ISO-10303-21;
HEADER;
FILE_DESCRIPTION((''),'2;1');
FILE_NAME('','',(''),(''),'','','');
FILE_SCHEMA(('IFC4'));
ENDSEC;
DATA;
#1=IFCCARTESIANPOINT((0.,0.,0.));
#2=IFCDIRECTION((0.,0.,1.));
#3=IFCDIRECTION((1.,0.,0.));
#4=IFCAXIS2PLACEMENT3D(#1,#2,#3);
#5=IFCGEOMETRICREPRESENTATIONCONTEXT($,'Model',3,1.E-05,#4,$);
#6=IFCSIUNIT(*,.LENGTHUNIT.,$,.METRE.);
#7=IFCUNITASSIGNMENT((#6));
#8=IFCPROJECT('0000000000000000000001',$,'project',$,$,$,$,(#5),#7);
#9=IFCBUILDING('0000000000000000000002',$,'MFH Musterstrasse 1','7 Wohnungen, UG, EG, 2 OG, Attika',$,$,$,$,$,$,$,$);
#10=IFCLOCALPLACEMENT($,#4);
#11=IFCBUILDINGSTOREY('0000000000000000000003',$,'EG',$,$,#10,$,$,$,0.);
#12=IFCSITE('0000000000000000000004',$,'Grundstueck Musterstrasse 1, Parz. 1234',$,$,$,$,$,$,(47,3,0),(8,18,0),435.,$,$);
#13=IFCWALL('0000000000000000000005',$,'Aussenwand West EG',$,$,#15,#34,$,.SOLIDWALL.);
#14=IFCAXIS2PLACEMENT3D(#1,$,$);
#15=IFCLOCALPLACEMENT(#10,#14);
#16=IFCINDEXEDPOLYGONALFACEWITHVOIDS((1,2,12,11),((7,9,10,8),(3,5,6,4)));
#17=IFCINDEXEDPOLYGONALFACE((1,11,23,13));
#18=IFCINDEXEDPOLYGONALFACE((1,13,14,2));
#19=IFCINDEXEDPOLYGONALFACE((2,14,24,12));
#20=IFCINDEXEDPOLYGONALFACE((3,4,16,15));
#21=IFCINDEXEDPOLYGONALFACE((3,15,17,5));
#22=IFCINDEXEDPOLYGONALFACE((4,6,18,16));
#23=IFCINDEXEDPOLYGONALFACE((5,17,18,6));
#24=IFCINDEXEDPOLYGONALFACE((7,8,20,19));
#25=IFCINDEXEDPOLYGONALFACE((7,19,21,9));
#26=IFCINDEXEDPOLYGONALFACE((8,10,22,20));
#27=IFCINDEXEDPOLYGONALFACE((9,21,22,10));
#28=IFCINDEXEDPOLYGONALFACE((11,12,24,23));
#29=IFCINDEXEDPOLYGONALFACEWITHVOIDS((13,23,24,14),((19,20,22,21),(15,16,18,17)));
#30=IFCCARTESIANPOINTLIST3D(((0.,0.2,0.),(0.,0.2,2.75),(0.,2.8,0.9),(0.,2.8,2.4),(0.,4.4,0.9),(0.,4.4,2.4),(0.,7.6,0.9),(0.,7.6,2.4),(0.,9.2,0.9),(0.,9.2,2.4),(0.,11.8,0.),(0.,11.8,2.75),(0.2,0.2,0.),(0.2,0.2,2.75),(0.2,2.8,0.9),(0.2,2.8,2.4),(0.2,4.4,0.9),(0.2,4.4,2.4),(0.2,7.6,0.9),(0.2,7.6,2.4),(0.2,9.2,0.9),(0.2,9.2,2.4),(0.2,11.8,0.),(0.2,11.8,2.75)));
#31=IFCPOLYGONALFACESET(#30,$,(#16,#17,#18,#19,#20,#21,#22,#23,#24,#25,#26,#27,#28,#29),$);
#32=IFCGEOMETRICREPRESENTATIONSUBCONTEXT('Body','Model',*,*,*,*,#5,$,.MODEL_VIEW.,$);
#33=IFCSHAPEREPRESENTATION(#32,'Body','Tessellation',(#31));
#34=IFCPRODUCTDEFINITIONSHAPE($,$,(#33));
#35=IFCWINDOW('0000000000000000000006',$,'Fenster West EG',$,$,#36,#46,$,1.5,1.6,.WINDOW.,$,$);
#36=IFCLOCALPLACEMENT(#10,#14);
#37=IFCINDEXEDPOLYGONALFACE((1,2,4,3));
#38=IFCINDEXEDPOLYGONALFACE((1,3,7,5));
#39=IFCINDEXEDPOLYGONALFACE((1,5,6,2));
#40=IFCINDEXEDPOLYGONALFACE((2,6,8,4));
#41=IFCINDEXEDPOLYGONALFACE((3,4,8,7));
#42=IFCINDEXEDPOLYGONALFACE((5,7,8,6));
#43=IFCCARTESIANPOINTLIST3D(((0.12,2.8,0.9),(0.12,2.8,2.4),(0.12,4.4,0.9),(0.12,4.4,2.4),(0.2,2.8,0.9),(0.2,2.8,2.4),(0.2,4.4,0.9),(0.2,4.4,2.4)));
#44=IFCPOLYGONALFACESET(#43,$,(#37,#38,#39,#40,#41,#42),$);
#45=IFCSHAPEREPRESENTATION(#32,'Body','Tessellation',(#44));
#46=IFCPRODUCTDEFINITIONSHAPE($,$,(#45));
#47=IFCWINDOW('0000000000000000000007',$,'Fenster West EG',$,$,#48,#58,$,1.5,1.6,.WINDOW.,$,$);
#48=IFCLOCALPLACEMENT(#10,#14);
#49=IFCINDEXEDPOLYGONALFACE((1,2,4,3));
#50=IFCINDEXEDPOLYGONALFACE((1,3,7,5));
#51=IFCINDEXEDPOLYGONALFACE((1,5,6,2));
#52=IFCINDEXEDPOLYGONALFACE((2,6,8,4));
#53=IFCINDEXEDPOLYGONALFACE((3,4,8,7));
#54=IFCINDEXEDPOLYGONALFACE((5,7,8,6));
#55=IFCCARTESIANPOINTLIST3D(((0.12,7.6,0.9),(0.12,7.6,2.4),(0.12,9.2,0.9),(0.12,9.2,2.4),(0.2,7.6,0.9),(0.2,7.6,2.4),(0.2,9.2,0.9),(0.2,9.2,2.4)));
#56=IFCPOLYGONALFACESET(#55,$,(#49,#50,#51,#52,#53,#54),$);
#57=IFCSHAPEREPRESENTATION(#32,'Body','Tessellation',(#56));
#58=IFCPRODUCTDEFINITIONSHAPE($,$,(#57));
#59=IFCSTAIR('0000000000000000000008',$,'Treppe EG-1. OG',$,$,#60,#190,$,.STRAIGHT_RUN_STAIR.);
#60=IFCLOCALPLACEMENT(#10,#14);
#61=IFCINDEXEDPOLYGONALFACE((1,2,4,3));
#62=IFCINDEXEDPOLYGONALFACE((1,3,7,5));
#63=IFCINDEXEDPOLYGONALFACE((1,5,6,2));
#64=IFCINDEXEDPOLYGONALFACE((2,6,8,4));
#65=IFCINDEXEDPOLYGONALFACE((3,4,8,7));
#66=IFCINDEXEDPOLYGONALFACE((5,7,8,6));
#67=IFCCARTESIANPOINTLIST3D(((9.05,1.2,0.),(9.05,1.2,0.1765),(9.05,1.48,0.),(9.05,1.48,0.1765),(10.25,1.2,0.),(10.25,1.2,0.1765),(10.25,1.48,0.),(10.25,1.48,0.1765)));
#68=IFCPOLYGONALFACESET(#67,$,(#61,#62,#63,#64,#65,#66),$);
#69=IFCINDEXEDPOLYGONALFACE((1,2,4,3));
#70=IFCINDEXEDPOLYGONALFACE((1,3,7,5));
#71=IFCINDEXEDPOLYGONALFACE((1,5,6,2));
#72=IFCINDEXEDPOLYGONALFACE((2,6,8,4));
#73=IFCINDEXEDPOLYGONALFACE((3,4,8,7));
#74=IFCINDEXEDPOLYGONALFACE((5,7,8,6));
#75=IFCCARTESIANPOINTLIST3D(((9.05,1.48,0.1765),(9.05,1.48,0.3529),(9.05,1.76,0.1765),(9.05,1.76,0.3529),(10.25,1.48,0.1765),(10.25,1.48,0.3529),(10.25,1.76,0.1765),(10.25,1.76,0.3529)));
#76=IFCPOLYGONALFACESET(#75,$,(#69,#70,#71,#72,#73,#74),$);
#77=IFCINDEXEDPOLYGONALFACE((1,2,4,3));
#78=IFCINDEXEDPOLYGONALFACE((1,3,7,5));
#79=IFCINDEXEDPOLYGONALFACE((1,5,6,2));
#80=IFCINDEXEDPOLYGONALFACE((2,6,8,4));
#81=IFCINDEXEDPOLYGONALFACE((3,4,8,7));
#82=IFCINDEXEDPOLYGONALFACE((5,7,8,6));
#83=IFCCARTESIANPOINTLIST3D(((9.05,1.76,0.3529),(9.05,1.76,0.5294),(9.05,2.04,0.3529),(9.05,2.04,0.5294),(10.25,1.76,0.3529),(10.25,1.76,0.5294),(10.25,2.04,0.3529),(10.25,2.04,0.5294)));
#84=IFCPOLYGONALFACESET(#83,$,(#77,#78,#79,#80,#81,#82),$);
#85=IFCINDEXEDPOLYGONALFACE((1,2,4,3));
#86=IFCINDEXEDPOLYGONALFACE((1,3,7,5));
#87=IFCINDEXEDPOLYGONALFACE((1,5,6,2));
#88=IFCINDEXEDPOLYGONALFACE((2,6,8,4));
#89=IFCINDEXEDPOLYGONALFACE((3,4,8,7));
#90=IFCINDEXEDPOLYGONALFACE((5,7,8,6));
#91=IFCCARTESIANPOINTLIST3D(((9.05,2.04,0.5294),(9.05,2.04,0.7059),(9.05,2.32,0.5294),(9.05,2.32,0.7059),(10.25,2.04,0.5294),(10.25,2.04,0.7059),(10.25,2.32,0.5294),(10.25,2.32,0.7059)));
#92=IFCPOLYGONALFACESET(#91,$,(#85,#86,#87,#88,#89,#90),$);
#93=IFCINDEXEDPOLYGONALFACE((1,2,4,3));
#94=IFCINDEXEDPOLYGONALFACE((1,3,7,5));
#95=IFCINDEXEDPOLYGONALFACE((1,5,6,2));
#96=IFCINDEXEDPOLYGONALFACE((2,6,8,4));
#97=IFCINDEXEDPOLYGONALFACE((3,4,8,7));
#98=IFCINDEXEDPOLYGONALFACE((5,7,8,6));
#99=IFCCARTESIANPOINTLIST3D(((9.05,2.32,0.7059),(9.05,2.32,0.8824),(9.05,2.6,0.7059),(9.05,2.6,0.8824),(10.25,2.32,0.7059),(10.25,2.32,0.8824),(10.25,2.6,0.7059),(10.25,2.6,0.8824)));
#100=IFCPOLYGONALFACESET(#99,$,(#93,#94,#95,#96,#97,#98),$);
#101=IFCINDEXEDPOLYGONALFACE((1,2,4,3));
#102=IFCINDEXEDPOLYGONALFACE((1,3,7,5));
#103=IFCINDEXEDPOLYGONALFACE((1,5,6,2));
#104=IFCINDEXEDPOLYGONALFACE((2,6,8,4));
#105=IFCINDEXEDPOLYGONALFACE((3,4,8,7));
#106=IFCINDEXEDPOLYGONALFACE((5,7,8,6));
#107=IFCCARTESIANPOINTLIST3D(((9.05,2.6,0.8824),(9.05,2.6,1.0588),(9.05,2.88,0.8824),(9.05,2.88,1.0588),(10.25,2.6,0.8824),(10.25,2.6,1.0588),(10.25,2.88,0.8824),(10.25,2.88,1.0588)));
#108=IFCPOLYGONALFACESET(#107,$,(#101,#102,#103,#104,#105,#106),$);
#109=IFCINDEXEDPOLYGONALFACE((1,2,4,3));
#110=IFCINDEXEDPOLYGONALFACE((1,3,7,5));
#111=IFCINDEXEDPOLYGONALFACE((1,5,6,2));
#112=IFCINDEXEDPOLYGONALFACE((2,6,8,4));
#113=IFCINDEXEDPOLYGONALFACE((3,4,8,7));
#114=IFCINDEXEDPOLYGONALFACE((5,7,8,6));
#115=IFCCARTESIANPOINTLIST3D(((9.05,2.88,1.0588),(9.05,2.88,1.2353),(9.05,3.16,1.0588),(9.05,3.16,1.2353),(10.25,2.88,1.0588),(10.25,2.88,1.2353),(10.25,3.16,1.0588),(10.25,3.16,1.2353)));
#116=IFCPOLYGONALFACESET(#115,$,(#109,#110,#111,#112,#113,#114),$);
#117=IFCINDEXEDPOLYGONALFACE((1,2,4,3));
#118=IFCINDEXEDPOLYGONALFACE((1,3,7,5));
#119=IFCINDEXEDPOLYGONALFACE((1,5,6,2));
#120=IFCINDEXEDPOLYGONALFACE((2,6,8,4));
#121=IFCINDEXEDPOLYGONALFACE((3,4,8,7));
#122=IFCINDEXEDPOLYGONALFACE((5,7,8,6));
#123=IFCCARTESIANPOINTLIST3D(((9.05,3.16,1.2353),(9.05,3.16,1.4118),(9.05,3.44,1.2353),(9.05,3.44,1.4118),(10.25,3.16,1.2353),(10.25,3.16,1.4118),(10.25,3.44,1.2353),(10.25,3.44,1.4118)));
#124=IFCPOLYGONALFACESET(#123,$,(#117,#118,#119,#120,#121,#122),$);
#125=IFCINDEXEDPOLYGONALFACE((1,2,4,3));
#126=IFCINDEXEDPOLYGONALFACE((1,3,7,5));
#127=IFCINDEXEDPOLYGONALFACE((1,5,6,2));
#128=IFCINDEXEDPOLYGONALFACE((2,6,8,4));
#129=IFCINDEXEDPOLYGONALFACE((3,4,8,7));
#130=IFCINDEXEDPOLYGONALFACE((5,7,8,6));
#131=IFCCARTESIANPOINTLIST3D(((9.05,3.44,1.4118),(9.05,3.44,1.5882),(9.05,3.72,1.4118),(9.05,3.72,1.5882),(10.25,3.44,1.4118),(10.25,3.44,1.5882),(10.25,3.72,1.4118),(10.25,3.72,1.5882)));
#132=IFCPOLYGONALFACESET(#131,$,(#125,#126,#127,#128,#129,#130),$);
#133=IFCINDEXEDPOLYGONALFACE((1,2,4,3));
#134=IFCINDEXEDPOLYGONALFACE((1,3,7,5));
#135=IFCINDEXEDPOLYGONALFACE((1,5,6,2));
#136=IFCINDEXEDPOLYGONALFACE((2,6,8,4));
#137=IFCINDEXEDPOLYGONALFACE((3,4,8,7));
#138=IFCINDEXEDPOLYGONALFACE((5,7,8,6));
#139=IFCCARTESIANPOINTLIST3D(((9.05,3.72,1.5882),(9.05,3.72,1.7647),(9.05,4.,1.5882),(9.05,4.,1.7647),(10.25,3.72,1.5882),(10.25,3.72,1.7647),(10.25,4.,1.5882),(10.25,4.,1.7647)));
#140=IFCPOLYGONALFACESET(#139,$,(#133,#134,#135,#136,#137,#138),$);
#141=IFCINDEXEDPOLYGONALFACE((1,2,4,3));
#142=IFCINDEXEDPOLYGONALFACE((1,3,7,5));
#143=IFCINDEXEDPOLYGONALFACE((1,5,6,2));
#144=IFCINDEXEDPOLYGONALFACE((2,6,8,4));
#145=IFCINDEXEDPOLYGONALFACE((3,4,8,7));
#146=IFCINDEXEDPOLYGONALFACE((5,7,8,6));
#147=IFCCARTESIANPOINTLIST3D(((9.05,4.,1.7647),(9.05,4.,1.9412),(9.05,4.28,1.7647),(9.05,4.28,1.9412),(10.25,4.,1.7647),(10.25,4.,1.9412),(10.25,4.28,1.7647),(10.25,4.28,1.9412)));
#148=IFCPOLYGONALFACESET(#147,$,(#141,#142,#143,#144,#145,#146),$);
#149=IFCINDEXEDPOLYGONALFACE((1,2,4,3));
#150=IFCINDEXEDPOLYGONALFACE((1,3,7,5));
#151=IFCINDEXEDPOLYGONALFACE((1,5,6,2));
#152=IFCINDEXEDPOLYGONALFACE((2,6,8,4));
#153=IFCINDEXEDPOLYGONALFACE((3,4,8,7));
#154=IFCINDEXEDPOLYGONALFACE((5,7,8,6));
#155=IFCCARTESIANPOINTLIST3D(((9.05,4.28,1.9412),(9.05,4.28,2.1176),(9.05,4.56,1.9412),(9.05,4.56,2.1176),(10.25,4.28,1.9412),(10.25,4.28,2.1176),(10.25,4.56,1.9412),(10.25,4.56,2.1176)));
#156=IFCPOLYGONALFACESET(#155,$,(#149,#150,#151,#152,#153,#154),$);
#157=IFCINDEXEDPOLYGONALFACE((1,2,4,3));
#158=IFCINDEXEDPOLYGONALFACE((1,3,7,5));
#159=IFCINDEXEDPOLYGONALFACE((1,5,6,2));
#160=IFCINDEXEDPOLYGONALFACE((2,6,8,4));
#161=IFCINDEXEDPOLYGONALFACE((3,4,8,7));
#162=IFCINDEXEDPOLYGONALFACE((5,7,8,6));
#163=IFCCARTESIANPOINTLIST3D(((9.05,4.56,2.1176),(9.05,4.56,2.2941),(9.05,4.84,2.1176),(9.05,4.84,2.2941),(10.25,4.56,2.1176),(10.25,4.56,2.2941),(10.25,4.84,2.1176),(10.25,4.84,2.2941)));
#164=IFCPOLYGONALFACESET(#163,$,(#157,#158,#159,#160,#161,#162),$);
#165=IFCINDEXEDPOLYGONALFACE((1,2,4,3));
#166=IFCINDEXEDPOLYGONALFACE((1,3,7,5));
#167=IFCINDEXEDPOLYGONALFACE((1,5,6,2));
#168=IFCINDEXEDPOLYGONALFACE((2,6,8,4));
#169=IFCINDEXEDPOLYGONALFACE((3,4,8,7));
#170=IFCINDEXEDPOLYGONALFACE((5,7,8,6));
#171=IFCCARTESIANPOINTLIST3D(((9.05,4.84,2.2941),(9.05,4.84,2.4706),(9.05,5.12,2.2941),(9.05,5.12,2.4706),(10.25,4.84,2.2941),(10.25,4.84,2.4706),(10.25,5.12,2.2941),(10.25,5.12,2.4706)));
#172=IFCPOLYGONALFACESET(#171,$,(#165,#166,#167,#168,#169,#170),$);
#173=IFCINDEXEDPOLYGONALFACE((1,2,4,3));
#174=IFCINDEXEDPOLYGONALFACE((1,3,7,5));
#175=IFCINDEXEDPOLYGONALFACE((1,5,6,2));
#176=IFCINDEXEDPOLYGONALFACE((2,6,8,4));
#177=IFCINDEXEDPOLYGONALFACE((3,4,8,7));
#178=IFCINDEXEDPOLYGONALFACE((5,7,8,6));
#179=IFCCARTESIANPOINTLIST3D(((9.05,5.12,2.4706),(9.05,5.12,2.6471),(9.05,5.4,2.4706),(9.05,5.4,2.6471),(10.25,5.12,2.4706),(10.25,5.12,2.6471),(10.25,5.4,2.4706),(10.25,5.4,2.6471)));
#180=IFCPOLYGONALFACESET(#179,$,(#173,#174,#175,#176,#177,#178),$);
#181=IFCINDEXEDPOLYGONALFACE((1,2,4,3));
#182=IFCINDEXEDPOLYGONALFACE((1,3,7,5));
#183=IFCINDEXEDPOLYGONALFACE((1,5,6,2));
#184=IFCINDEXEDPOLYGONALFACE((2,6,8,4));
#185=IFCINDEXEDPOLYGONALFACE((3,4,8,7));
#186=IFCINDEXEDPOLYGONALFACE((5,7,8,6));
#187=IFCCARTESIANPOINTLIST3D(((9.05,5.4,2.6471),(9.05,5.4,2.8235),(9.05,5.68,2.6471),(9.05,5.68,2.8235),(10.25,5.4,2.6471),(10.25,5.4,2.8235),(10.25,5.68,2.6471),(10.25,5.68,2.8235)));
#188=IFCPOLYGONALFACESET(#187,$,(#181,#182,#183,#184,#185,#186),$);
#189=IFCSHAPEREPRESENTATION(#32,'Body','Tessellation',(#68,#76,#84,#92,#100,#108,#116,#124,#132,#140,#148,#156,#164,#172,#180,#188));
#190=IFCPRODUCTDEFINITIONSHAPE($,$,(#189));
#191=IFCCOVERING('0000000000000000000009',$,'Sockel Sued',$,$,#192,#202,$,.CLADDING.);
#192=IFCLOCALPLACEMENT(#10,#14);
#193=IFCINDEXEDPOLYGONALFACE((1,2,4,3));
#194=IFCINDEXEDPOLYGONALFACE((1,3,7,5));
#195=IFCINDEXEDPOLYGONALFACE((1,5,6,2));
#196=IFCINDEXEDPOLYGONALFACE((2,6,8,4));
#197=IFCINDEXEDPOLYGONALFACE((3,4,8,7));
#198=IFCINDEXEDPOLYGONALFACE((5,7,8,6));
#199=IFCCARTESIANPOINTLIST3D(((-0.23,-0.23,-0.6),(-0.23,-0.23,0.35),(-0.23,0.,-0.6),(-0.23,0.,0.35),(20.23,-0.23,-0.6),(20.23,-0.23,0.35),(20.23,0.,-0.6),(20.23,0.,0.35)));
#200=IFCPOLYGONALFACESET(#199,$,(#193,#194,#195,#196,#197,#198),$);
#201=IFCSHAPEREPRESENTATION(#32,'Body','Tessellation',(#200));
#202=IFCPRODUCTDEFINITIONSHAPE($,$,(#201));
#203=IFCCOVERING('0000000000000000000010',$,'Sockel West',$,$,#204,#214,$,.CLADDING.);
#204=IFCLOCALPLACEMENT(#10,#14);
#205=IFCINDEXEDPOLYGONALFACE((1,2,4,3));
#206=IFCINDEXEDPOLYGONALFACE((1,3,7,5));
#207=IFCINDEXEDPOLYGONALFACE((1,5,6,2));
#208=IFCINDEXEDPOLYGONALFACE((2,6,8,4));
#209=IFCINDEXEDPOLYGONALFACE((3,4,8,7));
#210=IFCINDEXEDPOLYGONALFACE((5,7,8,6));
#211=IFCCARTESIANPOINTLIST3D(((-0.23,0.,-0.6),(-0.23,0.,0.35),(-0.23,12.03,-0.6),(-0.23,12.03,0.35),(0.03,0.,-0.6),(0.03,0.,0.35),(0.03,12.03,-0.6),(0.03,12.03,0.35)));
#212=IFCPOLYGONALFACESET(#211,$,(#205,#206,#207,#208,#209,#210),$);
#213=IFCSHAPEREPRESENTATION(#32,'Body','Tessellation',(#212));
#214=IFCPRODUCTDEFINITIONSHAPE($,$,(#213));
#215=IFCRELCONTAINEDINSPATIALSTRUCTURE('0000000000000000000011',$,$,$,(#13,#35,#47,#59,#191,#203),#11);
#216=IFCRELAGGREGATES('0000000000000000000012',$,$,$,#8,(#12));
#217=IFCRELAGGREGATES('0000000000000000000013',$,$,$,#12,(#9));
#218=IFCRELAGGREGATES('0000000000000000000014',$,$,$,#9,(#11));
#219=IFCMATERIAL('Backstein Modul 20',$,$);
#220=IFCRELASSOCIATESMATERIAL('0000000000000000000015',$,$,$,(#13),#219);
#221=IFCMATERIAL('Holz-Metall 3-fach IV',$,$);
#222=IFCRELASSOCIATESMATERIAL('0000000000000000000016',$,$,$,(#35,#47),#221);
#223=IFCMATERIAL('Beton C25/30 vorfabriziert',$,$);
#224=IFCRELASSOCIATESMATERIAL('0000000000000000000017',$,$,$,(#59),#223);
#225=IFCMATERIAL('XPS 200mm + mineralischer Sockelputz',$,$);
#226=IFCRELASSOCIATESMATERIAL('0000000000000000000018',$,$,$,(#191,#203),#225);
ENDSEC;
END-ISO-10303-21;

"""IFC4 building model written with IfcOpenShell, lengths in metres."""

from ifc_helpers import new_model, si_unit, frame, frame_2d, origin_with_axes, place, context, subcontext, project, spatial, rectangle, extrude, material, element, fill, save


model = new_model("IFC4")

# Units and contexts
model_context = context("Model", 3, precision=1e-05, world=origin_with_axes())
body_context = subcontext(model_context, "Body", "Model", "MODEL_VIEW")
ifc_project = project(units=[si_unit("LENGTHUNIT", "METRE")], contexts=[model_context])

# Site, building, storey
site = spatial("IfcSite", under=ifc_project, Name="Grundstueck Musterstrasse 1, Parz. 1234", RefLatitude=(47, 3, 0), RefLongitude=(8, 18, 0), RefElevation=435.0)
building = spatial("IfcBuilding", under=site, Name="MFH Musterstrasse 1", Description="7 Wohnungen, UG, EG, 2 OG, Attika")
storey_placement = place(None, origin_with_axes())
storey = spatial("IfcBuildingStorey", under=building, at=storey_placement, Name="EG", Elevation=0.0)

# Shared definitions
ifc_material_1 = material(Name="Backstein Modul 20")
ifc_material_2 = material(Name="Holz-Metall 3-fach IV")

# Wall, openings, windows
wall_1_placement = place(storey_placement, frame((0.0, 0.2, 0.0), z_axis=(0.0, 0.0, 1.0), x_axis=(1.0, 0.0, 0.0)))
wall_1 = element("IfcWall", 1, at=wall_1_placement, inside=storey, material=ifc_material_1, Name="Aussenwand West EG", PredefinedType="SOLIDWALL", context=body_context, shape_type="SweptSolid", body=[
    extrude(rectangle(XDim=0.2, YDim=11.6, at=frame_2d((0.1, 5.8))), origin_with_axes(), (0.0, 0.0, 1.0), 2.75),
])
opening_1_placement = place(wall_1_placement, frame((-0.21, 2.6, 0.9), z_axis=(0.0, 0.0, 1.0), x_axis=(1.0, 0.0, 0.0)))
opening_1 = element("IfcOpeningElement", 2, at=opening_1_placement, cuts=wall_1, context=body_context, shape_type="SweptSolid", body=[
    extrude(rectangle(XDim=0.42, YDim=1.6, at=frame_2d((0.21, 0.8))), origin_with_axes(), (0.0, 0.0, 1.0), 1.5),
])
opening_2_placement = place(wall_1_placement, frame((-0.21, 7.4, 0.9), z_axis=(0.0, 0.0, 1.0), x_axis=(1.0, 0.0, 0.0)))
opening_2 = element("IfcOpeningElement", 3, at=opening_2_placement, cuts=wall_1, context=body_context, shape_type="SweptSolid", body=[
    extrude(rectangle(XDim=0.42, YDim=1.6, at=frame_2d((0.21, 0.8))), origin_with_axes(), (0.0, 0.0, 1.0), 1.5),
])
window_1_placement = place(storey_placement, frame((0.12, 2.8, 0.9), z_axis=(0.0, 0.0, 1.0), x_axis=(1.0, 0.0, 0.0)))
window_1 = element("IfcWindow", 4, at=window_1_placement, inside=storey, material=ifc_material_2, Name="Fenster West EG", OverallHeight=1.5, OverallWidth=1.6, PredefinedType="WINDOW", context=body_context, shape_type="SweptSolid", body=[
    extrude(rectangle(XDim=0.08, YDim=1.6, at=frame_2d((0.04, 0.8))), origin_with_axes(), (0.0, 0.0, 1.0), 1.5),
])
fill(opening_1, window_1)
window_2_placement = place(storey_placement, frame((0.12, 7.6, 0.9), z_axis=(0.0, 0.0, 1.0), x_axis=(1.0, 0.0, 0.0)))
window_2 = element("IfcWindow", 5, at=window_2_placement, inside=storey, material=ifc_material_2, Name="Fenster West EG", OverallHeight=1.5, OverallWidth=1.6, PredefinedType="WINDOW", context=body_context, shape_type="SweptSolid", body=[
    extrude(rectangle(XDim=0.08, YDim=1.6, at=frame_2d((0.04, 0.8))), origin_with_axes(), (0.0, 0.0, 1.0), 1.5),
])
fill(opening_2, window_2)

# Stair
ifc_material_3 = material(Name="Beton C25/30 vorfabriziert")
stair_placement = place(storey_placement, origin_with_axes())
element("IfcStair", 6, at=stair_placement, inside=storey, material=ifc_material_3, Name="Treppe EG-1. OG", PredefinedType="STRAIGHT_RUN_STAIR", context=body_context, shape_type="SweptSolid", body=[
    extrude(rectangle(XDim=1.2, YDim=0.28, at=frame_2d((0.6, 0.14))), frame((9.05, 1.2, 0.0)), (0.0, 0.0, 1.0), 0.1765),
    extrude(rectangle(XDim=1.2, YDim=0.28, at=frame_2d((0.6, 0.14))), frame((9.05, 1.48, 0.1765)), (0.0, 0.0, 1.0), 0.1765),
    extrude(rectangle(XDim=1.2, YDim=0.28, at=frame_2d((0.6, 0.14))), frame((9.05, 1.76, 0.3529)), (0.0, 0.0, 1.0), 0.1765),
    extrude(rectangle(XDim=1.2, YDim=0.28, at=frame_2d((0.6, 0.14))), frame((9.05, 2.04, 0.5294)), (0.0, 0.0, 1.0), 0.1765),
    extrude(rectangle(XDim=1.2, YDim=0.28, at=frame_2d((0.6, 0.14))), frame((9.05, 2.32, 0.7059)), (0.0, 0.0, 1.0), 0.1765),
    extrude(rectangle(XDim=1.2, YDim=0.28, at=frame_2d((0.6, 0.14))), frame((9.05, 2.6, 0.8824)), (0.0, 0.0, 1.0), 0.1765),
    extrude(rectangle(XDim=1.2, YDim=0.28, at=frame_2d((0.6, 0.14))), frame((9.05, 2.88, 1.0588)), (0.0, 0.0, 1.0), 0.1765),
    extrude(rectangle(XDim=1.2, YDim=0.28, at=frame_2d((0.6, 0.14))), frame((9.05, 3.16, 1.2353)), (0.0, 0.0, 1.0), 0.1765),
    extrude(rectangle(XDim=1.2, YDim=0.28, at=frame_2d((0.6, 0.14))), frame((9.05, 3.44, 1.4118)), (0.0, 0.0, 1.0), 0.1765),
    extrude(rectangle(XDim=1.2, YDim=0.28, at=frame_2d((0.6, 0.14))), frame((9.05, 3.72, 1.5882)), (0.0, 0.0, 1.0), 0.1765),
    extrude(rectangle(XDim=1.2, YDim=0.28, at=frame_2d((0.6, 0.14))), frame((9.05, 4.0, 1.7647)), (0.0, 0.0, 1.0), 0.1765),
    extrude(rectangle(XDim=1.2, YDim=0.28, at=frame_2d((0.6, 0.14))), frame((9.05, 4.28, 1.9412)), (0.0, 0.0, 1.0), 0.1765),
    extrude(rectangle(XDim=1.2, YDim=0.28, at=frame_2d((0.6, 0.14))), frame((9.05, 4.56, 2.1176)), (0.0, 0.0, 1.0), 0.1765),
    extrude(rectangle(XDim=1.2, YDim=0.28, at=frame_2d((0.6, 0.14))), frame((9.05, 4.84, 2.2941)), (0.0, 0.0, 1.0), 0.1765),
    extrude(rectangle(XDim=1.2, YDim=0.28, at=frame_2d((0.6, 0.14))), frame((9.05, 5.12, 2.4706)), (0.0, 0.0, 1.0), 0.1765),
    extrude(rectangle(XDim=1.2, YDim=0.28, at=frame_2d((0.6, 0.14))), frame((9.05, 5.4, 2.6471)), (0.0, 0.0, 1.0), 0.1765),
])

# Coverings
ifc_material_4 = material(Name="XPS 200mm + mineralischer Sockelputz")
covering_1_placement = place(storey_placement, frame((-0.23, -0.23, -0.6), z_axis=(0.0, 0.0, 1.0), x_axis=(1.0, 0.0, 0.0)))
element("IfcCovering", 7, at=covering_1_placement, inside=storey, material=ifc_material_4, Name="Sockel Sued", PredefinedType="CLADDING", context=body_context, shape_type="SweptSolid", body=[
    extrude(rectangle(XDim=20.46, YDim=0.23, at=frame_2d((10.23, 0.115))), origin_with_axes(), (0.0, 0.0, 1.0), 0.95),
])
covering_2_placement = place(storey_placement, frame((-0.23, 0.0, -0.6), z_axis=(0.0, 0.0, 1.0), x_axis=(1.0, 0.0, 0.0)))
element("IfcCovering", 8, at=covering_2_placement, inside=storey, material=ifc_material_4, Name="Sockel West", PredefinedType="CLADDING", context=body_context, shape_type="SweptSolid", body=[
    extrude(rectangle(XDim=0.26, YDim=12.03, at=frame_2d((0.13, 6.015))), origin_with_axes(), (0.0, 0.0, 1.0), 0.95),
])

save(model, "model.ifc")
